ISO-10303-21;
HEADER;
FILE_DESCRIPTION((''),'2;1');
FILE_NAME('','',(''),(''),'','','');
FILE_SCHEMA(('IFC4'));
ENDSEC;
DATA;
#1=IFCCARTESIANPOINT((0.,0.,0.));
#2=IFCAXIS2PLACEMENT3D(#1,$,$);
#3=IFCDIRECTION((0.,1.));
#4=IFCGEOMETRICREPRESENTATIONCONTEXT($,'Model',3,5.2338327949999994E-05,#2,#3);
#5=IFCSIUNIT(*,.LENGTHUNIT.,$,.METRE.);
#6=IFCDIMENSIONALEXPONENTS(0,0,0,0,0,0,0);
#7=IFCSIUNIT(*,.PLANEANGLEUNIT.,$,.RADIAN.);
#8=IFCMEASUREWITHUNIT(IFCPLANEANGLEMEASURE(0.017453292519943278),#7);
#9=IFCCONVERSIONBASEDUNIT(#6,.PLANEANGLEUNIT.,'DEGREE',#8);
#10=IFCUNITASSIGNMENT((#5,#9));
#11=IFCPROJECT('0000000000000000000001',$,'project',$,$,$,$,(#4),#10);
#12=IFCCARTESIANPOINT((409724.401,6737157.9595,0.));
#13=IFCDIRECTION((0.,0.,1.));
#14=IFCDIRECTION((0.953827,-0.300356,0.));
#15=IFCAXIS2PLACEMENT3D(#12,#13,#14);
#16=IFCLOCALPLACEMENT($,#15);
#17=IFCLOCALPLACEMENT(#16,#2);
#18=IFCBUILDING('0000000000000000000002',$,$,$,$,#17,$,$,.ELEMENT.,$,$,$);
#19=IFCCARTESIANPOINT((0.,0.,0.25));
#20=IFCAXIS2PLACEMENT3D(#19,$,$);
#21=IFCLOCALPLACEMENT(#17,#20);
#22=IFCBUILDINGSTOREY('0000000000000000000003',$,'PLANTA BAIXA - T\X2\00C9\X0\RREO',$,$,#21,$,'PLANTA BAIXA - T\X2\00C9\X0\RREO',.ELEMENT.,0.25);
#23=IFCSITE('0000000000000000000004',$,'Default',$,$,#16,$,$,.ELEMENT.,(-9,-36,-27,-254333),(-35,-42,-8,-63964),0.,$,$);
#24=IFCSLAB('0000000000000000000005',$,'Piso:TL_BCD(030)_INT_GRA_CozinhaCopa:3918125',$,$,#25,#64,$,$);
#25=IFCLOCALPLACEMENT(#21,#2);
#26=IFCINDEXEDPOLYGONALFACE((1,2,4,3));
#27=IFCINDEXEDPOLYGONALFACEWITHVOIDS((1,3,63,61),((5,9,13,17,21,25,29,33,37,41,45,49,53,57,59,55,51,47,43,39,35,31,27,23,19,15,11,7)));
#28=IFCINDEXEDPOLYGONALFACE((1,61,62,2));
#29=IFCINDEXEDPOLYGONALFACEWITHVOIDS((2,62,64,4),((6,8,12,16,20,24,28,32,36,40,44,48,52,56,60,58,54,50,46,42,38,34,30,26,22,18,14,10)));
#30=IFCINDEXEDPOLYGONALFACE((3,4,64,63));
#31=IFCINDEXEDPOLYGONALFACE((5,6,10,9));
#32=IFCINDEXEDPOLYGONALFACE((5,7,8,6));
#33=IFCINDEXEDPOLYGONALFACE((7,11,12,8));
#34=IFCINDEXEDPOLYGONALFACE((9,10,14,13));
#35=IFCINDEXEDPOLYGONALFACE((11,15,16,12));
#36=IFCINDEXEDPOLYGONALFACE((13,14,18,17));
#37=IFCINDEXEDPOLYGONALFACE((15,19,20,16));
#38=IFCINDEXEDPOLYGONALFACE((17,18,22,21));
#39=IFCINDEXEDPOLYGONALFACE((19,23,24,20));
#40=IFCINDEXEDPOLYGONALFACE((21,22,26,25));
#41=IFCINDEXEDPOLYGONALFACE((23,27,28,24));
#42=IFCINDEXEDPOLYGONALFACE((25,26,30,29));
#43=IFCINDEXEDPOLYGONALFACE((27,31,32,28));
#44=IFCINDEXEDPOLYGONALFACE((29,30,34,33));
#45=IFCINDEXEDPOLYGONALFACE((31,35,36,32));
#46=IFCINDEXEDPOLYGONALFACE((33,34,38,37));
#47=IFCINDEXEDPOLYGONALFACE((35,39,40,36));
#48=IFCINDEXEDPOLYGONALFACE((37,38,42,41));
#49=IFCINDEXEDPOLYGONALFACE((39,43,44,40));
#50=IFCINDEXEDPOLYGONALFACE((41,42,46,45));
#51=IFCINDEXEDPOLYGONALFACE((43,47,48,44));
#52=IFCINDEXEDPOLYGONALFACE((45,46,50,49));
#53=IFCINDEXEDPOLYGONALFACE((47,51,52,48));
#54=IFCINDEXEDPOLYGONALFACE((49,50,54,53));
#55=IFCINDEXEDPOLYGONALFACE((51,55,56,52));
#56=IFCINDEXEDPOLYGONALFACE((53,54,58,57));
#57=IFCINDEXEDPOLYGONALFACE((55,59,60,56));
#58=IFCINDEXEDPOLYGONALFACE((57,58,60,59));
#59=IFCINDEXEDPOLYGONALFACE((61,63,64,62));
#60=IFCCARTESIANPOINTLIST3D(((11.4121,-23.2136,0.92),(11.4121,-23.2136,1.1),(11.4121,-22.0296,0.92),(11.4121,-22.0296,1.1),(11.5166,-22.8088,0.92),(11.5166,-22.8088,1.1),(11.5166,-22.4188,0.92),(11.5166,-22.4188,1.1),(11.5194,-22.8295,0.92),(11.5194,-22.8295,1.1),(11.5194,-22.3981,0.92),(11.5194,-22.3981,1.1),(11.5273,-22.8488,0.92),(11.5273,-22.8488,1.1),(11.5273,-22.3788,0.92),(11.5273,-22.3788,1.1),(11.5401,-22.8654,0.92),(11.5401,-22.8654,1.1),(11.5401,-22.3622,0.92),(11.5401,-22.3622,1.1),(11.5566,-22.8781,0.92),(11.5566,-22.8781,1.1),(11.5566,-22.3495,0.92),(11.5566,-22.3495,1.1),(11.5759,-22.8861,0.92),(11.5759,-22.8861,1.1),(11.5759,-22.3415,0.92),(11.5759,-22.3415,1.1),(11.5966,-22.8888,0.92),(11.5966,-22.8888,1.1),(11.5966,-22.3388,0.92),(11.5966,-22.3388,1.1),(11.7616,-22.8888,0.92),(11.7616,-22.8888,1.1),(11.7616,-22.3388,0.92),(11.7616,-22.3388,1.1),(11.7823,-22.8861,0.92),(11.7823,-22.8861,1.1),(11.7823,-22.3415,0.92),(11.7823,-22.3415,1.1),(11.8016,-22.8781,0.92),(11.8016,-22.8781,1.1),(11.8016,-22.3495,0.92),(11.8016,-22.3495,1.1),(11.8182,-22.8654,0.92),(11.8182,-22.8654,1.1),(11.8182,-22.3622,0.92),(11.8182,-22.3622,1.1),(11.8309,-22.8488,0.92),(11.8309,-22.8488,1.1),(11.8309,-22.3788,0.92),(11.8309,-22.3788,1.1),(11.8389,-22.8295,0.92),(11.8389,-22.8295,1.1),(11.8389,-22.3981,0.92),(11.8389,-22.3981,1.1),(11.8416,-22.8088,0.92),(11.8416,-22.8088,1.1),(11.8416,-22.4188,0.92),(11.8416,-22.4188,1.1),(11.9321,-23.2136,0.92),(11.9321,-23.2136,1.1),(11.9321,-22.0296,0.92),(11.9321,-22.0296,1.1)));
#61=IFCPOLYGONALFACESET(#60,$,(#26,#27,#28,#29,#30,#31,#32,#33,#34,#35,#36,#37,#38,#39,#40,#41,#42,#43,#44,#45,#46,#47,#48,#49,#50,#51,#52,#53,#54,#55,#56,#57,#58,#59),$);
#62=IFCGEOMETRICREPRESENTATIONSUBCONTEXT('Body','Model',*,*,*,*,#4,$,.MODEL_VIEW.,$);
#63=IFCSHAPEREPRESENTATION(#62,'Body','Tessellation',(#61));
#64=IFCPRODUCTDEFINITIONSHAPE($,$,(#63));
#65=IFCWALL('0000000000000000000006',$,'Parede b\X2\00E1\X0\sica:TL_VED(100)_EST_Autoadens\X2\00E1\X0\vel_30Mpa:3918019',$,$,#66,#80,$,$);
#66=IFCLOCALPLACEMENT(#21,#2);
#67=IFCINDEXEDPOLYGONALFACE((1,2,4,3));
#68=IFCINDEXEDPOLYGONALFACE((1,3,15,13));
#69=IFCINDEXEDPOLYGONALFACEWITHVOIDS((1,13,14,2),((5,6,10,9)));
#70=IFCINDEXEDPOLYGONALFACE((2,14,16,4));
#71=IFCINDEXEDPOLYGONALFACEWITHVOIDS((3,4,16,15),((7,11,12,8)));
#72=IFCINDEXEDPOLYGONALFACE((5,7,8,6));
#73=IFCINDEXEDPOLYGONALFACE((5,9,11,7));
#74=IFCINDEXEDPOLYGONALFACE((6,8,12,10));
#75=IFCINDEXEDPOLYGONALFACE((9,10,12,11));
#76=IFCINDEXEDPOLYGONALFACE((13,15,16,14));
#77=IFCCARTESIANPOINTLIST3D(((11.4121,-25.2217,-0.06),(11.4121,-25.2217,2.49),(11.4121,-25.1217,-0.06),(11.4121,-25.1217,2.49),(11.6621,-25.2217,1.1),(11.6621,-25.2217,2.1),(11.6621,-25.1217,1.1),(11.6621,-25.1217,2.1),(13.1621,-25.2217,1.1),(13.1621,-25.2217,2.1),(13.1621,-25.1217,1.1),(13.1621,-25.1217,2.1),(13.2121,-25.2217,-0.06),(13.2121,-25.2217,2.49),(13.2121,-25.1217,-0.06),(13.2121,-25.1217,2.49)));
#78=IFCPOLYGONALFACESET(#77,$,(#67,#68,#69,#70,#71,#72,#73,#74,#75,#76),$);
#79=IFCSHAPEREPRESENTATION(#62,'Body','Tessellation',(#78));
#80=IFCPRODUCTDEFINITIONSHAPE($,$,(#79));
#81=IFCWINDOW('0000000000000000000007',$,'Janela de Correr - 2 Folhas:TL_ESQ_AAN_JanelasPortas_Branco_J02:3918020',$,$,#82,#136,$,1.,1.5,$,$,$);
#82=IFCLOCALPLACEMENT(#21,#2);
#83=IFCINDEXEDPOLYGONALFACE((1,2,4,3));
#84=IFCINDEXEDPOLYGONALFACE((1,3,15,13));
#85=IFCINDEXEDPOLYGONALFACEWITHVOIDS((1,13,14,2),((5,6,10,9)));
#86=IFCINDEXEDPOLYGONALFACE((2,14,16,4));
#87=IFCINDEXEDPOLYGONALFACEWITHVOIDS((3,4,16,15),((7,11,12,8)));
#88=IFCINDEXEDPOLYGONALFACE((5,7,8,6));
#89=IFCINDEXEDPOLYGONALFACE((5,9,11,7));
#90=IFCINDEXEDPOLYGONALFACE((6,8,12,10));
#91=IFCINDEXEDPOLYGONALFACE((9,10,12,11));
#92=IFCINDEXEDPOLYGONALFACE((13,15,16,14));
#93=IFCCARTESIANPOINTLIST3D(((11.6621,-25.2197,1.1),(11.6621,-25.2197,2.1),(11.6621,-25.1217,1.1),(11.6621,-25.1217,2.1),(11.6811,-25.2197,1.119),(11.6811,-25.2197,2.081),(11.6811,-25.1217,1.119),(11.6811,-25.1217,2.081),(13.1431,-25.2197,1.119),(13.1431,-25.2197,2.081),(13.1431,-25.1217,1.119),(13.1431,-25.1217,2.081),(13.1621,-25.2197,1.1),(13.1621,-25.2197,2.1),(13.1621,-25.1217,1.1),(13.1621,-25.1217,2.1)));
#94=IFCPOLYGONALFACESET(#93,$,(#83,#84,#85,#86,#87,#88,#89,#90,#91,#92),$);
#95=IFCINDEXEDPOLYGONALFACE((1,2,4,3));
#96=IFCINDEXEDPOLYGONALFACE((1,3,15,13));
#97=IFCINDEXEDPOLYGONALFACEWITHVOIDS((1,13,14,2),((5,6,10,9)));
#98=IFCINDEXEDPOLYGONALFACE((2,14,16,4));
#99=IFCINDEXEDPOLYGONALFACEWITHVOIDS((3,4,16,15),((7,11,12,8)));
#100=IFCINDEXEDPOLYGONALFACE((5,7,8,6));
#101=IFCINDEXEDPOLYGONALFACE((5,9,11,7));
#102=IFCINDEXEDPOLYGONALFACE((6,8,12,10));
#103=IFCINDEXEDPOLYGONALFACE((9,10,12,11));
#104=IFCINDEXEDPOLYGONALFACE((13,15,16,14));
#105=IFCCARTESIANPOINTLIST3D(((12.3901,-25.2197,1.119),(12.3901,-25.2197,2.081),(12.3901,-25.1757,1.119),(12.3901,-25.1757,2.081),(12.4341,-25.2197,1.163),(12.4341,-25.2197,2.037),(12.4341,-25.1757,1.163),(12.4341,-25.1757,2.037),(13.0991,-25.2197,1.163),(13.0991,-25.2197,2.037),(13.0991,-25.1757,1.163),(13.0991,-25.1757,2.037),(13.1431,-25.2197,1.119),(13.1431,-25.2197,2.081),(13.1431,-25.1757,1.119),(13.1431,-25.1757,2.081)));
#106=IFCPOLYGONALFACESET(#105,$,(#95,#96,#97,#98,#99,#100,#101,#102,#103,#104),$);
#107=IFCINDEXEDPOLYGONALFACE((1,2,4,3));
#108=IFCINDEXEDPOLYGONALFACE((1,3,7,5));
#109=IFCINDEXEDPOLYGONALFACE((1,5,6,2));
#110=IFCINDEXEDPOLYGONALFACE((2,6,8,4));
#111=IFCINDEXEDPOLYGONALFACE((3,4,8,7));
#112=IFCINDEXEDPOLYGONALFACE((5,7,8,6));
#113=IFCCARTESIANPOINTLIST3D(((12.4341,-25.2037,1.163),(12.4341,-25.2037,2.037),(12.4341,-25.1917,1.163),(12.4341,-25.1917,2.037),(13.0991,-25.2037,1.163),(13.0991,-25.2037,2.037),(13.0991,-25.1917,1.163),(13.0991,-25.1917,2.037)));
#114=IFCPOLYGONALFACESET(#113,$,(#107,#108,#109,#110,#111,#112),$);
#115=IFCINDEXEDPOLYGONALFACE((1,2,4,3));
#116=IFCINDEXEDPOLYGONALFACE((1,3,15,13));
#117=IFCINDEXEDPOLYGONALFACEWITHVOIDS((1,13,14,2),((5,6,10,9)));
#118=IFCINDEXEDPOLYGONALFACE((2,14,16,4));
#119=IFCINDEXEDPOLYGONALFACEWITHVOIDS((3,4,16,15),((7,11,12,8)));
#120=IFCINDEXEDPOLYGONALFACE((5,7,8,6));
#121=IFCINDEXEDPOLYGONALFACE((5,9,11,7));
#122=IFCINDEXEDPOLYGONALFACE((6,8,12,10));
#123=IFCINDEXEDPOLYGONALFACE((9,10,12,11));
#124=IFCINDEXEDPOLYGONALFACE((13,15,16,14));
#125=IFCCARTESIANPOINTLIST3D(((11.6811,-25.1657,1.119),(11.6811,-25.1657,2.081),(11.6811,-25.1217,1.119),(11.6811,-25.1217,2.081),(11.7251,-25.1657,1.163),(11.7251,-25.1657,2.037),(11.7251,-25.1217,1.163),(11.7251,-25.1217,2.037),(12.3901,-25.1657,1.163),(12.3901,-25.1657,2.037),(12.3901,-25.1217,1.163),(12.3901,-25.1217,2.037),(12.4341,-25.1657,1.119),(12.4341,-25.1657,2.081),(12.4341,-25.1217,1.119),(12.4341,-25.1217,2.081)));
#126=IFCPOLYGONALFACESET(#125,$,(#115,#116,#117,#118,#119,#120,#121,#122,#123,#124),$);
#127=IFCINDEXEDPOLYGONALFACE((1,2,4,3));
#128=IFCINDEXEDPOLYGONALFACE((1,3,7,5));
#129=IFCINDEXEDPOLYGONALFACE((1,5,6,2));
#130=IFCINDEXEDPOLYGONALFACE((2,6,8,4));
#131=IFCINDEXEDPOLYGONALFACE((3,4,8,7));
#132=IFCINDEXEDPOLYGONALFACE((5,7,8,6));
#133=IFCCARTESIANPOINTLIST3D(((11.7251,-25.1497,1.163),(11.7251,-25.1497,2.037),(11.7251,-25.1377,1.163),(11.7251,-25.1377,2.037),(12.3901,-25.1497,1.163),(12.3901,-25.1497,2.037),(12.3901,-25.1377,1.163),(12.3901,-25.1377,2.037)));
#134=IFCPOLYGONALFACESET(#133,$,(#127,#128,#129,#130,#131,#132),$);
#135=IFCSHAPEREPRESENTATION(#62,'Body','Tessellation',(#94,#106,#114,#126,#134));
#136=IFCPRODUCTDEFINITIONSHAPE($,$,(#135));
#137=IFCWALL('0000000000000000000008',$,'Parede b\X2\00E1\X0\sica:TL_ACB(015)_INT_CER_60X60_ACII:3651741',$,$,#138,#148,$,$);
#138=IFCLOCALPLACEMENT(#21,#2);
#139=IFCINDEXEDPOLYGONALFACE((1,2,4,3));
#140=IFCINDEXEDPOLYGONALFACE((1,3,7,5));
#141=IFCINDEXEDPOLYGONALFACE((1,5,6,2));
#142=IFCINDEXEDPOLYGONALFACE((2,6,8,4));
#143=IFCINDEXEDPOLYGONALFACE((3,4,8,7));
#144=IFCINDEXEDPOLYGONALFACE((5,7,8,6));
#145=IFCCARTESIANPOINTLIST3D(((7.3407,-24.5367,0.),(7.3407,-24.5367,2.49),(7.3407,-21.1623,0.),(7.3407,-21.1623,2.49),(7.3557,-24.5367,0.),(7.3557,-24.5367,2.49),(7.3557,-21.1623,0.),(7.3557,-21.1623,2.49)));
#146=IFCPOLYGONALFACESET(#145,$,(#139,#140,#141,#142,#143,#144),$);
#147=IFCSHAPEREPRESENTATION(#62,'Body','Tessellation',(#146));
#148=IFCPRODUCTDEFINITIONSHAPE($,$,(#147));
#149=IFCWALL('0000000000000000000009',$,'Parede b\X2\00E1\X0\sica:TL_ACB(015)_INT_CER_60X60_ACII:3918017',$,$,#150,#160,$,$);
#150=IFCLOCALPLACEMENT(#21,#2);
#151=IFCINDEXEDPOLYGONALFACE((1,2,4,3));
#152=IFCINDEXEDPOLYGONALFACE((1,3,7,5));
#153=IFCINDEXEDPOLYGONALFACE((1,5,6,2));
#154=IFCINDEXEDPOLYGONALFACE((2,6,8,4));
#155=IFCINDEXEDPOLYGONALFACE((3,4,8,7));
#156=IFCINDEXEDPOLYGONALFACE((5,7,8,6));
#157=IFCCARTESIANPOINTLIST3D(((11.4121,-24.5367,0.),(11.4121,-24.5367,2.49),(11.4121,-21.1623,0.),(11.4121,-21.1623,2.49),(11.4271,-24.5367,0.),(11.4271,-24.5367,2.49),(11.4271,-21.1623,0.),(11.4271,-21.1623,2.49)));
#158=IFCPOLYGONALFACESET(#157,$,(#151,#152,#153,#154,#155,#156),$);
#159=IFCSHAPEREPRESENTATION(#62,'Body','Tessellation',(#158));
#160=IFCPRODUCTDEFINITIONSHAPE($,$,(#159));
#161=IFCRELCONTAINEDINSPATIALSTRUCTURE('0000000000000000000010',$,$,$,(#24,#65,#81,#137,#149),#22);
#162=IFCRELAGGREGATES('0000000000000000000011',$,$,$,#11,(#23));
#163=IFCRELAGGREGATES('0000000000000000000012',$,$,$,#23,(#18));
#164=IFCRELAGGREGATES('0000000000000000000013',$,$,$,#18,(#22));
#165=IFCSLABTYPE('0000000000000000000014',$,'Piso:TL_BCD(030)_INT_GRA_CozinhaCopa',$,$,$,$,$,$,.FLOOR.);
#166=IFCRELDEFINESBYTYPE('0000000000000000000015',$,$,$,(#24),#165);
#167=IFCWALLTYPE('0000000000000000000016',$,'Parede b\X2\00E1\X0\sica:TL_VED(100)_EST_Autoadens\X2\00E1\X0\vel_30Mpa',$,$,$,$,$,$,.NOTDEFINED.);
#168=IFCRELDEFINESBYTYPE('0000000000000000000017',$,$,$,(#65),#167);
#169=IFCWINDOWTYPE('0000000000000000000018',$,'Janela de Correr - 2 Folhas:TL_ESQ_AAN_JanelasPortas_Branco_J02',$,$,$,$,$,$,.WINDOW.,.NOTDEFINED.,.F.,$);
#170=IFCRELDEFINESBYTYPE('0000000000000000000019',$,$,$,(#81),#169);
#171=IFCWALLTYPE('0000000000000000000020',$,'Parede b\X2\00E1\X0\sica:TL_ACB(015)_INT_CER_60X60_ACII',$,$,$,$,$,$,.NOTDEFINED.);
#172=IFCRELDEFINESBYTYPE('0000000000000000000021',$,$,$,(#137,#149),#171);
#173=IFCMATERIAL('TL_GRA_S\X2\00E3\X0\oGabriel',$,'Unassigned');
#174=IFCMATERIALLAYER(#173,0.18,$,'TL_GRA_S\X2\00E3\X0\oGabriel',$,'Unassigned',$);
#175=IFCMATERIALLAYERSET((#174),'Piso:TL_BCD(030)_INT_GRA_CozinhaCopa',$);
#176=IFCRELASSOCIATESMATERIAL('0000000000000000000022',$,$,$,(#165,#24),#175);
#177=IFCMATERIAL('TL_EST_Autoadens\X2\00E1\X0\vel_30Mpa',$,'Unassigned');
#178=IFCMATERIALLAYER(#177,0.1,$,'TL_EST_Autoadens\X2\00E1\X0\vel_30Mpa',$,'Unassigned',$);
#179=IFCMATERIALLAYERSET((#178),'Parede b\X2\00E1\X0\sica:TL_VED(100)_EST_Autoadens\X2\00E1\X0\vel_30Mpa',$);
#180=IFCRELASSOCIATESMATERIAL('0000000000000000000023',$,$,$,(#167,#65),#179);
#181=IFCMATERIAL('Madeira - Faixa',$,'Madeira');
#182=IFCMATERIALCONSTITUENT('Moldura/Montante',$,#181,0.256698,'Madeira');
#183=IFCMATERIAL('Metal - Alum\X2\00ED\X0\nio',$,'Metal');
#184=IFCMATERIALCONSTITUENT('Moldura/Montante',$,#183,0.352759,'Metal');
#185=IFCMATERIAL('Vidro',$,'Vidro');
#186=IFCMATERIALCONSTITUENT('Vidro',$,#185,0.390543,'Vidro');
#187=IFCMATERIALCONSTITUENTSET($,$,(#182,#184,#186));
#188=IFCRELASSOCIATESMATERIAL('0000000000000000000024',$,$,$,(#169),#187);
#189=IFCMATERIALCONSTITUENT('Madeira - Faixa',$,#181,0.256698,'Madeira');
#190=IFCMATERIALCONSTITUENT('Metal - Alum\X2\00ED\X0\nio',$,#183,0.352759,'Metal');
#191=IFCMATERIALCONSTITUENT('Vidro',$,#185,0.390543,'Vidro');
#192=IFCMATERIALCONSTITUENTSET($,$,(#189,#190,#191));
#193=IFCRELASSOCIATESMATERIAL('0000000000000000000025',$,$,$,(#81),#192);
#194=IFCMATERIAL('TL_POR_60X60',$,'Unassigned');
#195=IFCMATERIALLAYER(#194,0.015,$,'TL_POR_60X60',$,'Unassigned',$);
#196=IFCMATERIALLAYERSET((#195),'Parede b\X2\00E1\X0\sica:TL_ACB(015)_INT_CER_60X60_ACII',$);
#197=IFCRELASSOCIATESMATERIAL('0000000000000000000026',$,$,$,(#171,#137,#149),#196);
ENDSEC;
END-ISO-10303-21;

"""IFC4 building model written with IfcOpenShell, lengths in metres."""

from ifc_helpers import new_model, entity, si_unit, converted_unit, direction, frame, frame_2d, origin, origin_2d_with_axis, place, context, subcontext, project, spatial, polyline, circle_curve, parameter, trimmed, segment, composite_curve, rectangle, outline, extrude, source, transform, mapped, material, layer, layer_set, layer_usage, constituent, constituent_set, type_object, type_shapes, element, fill, save


model = new_model("IFC4")

# Units and contexts
model_context = context("Model", 3, precision=5.2338327949999994e-05, world=origin(), true_north=direction((0.0, 1.0)))
body_context = subcontext(model_context, "Body", "Model", "MODEL_VIEW")
ifc_project = project(units=[si_unit("LENGTHUNIT", "METRE"), converted_unit("PLANEANGLEUNIT", "DEGREE", entity("IfcPlaneAngleMeasure", 0.017453292519943278), si_unit("PLANEANGLEUNIT", "RADIAN"), dimensions=[0, 0, 0, 0, 0, 0, 0])], contexts=[model_context])

# Site, building, storey
site_placement = place(None, frame((409724.401, 6737157.9595, 0.0), z_axis=(0.0, 0.0, 1.0), x_axis=(0.953827, -0.300356, 0.0)))
site = spatial("IfcSite", under=ifc_project, at=site_placement, Name="Default", CompositionType="ELEMENT", RefLatitude=(-9, -36, -27, -254333), RefLongitude=(-35, -42, -8, -63964), RefElevation=0.0)
building_placement = place(site_placement, origin())
building = spatial("IfcBuilding", under=site, at=building_placement, CompositionType="ELEMENT")
storey_placement = place(building_placement, frame((0.0, 0.0, 0.25)))
storey = spatial("IfcBuildingStorey", under=building, at=storey_placement, Name="PLANTA BAIXA - TÉRREO", LongName="PLANTA BAIXA - TÉRREO", CompositionType="ELEMENT", Elevation=0.25)

# Shared definitions
ifc_material_1 = material(Name="TL_POR_60X60", Category="Unassigned")

# Slab, opening
ifc_material_2 = material(Name="TL_GRA_SãoGabriel", Category="Unassigned")
ifc_layer_1 = layer(ifc_material_2, 0.18, Name="TL_GRA_SãoGabriel", Category="Unassigned")
ifc_layer_set_1 = layer_set([ifc_layer_1], Name="Piso:TL_BCD(030)_INT_GRA_CozinhaCopa")
ifc_layer_usage_1 = layer_usage(ifc_layer_set_1, "AXIS3", "POSITIVE", 0.0)
slab_type_1 = type_object("IfcSlabType", Name="Piso:TL_BCD(030)_INT_GRA_CozinhaCopa", PredefinedType="FLOOR", material=ifc_layer_set_1)
slab_1_placement = place(storey_placement, frame((11.4121, -23.2136, 0.92)))
slab_1 = element("IfcSlab", 1, at=slab_1_placement, inside=storey, type_object=slab_type_1, material=ifc_layer_usage_1, Name="Piso:TL_BCD(030)_INT_GRA_CozinhaCopa:3918125", context=body_context, shape_type="SweptSolid", body=[
    extrude(rectangle(XDim=1.184, YDim=0.52, at=frame_2d((0.0, 0.0), x_axis=(0.0, 1.0))), frame((0.26, 0.592, 0.18), z_axis=(0.0, 0.0, -1.0), x_axis=(-1.0, 0.0, 0.0)), (0.0, 0.0, 1.0), 0.18),
])
opening_1_placement = place(slab_1_placement, frame((-11.4121, 23.2136, 0.18)))
element("IfcOpeningElement", 2, at=opening_1_placement, cuts=slab_1, PredefinedType="OPENING", context=body_context, shape_type="SweptSolid", body=[
    extrude(outline(composite_curve([segment(polyline([(-0.195, -0.1625), (0.195, -0.1625)]), True, "CONTINUOUS"), segment(trimmed(circle_curve(frame_2d((0.195, -0.0825), x_axis=(-1.0, 0.0)), 0.08), [parameter(90.0)], [parameter(180.0)], True, "PARAMETER"), True, "CONTINUOUS"), segment(polyline([(0.275, -0.0825), (0.275, 0.0825)]), True, "CONTINUOUS"), segment(trimmed(circle_curve(frame_2d((0.195, 0.0825), x_axis=(-1.0, 0.0)), 0.08), [parameter(180.0)], [parameter(270.0)], True, "PARAMETER"), True, "CONTINUOUS"), segment(polyline([(0.195, 0.1625), (-0.195, 0.1625)]), True, "CONTINUOUS"), segment(trimmed(circle_curve(frame_2d((-0.195, 0.0825), x_axis=(-1.0, 0.0)), 0.08), [parameter(270.0)], [parameter(360.0)], True, "PARAMETER"), True, "CONTINUOUS"), segment(polyline([(-0.275, 0.0825), (-0.275, -0.0825)]), True, "CONTINUOUS"), segment(trimmed(circle_curve(frame_2d((-0.195, -0.0825), x_axis=(-1.0, 0.0)), 0.08), [parameter(360.0)], [parameter(90.0)], True, "PARAMETER"), True, "CONTINUOUS")], self_intersect=False)), frame((11.6791, -22.6138, -0.21), z_axis=(0.0, 0.0, 1.0), x_axis=(0.0, -1.0, 0.0)), (0.0, 0.0, 1.0), 0.21),
])

# Wall, opening, window
ifc_material_3 = material(Name="TL_EST_Autoadensável_30Mpa", Category="Unassigned")
ifc_layer_2 = layer(ifc_material_3, 0.1, Name="TL_EST_Autoadensável_30Mpa", Category="Unassigned")
ifc_layer_set_2 = layer_set([ifc_layer_2], Name="Parede básica:TL_VED(100)_EST_Autoadensável_30Mpa")
ifc_layer_usage_2 = layer_usage(ifc_layer_set_2, "AXIS2", "NEGATIVE", 0.05)
wall_type_1 = type_object("IfcWallType", Name="Parede básica:TL_VED(100)_EST_Autoadensável_30Mpa", PredefinedType="NOTDEFINED", material=ifc_layer_set_2)
wall_1_placement = place(storey_placement, frame((13.2121, -25.1717, -0.06), z_axis=(0.0, 0.0, 1.0), x_axis=(-1.0, 0.0, 0.0)))
wall_1 = element("IfcWall", 3, at=wall_1_placement, inside=storey, type_object=wall_type_1, material=ifc_layer_usage_2, Name="Parede básica:TL_VED(100)_EST_Autoadensável_30Mpa:3918019", context=body_context, shape_type="SweptSolid", body=[
    extrude(rectangle(XDim=1.8, YDim=0.1, at=frame_2d((0.9, 0.0), x_axis=(-1.0, 0.0))), origin(), (0.0, 0.0, 1.0), 2.55),
])
opening_2_placement = place(wall_1_placement, frame((0.05, -0.05, 1.16)))
opening_2 = element("IfcOpeningElement", 4, at=opening_2_placement, cuts=wall_1, PredefinedType="OPENING", context=body_context, shape_type="SweptSolid", body=[
    extrude(rectangle(XDim=1.0, YDim=1.5, at=frame_2d((0.5, 0.75), x_axis=(-1.0, 0.0))), frame((0.0, 0.0, 0.0), z_axis=(0.0, 1.0, 0.0), x_axis=(0.0, 0.0, 1.0)), (0.0, 0.0, 1.0), 0.1),
])
ifc_material_4 = material(Name="Madeira - Faixa", Category="Madeira")
ifc_constituent_1 = constituent(ifc_material_4, Name="Madeira - Faixa", Category="Madeira", fraction=0.256698)
ifc_material_5 = material(Name="Metal - Alumínio", Category="Metal")
ifc_constituent_2 = constituent(ifc_material_5, Name="Metal - Alumínio", Category="Metal", fraction=0.352759)
ifc_material_6 = material(Name="Vidro", Category="Vidro")
ifc_constituent_3 = constituent(ifc_material_6, Name="Vidro", Category="Vidro", fraction=0.390543)
ifc_constituent_set_1 = constituent_set(constituents=[ifc_constituent_1, ifc_constituent_2, ifc_constituent_3])
ifc_constituent_4 = constituent(ifc_material_4, Name="Moldura/Montante", Category="Madeira", fraction=0.256698)
ifc_constituent_5 = constituent(ifc_material_5, Name="Moldura/Montante", Category="Metal", fraction=0.352759)
ifc_constituent_6 = constituent(ifc_material_6, Name="Vidro", Category="Vidro", fraction=0.390543)
ifc_constituent_set_2 = constituent_set(constituents=[ifc_constituent_4, ifc_constituent_5, ifc_constituent_6])
window_type = type_object("IfcWindowType", Name="Janela de Correr - 2 Folhas:TL_ESQ_AAN_JanelasPortas_Branco_J02", ParameterTakesPrecedence=False, PartitioningType="NOTDEFINED", PredefinedType="WINDOW", material=ifc_constituent_set_2)
shared_shape_1 = source(origin(), body_context, "Body", "SweptSolid", [
    extrude(outline(polyline([(-0.75, -0.5), (0.75, -0.5), (0.75, 0.5), (-0.75, 0.5), (-0.75, -0.5)]), holes=[polyline([(-0.731, -0.481), (-0.731, 0.481), (0.731, 0.481), (0.731, -0.481), (-0.731, -0.481)])]), frame((0.75, 0.124, 0.5), z_axis=(0.0, -1.0, 0.0), x_axis=(-1.0, 0.0, 0.0)), (0.0, 0.0, 1.0), 0.098),
    extrude(outline(polyline([(-0.3765, -0.481), (0.3765, -0.481), (0.3765, 0.481), (-0.3765, 0.481), (-0.3765, -0.481)]), holes=[polyline([(-0.3325, -0.437), (-0.3325, 0.437), (0.3325, 0.437), (0.3325, -0.437), (-0.3325, -0.437)])]), frame((0.3955, 0.124, 0.5), z_axis=(0.0, -1.0, 0.0), x_axis=(-1.0, 0.0, 0.0)), (0.0, 0.0, 1.0), 0.044),
    extrude(rectangle(XDim=0.665, YDim=0.012, at=origin_2d_with_axis()), frame((0.3955, 0.102, 0.063), z_axis=(0.0, 0.0, 1.0), x_axis=(-1.0, 0.0, 0.0)), (0.0, 0.0, 1.0), 0.874),
    extrude(outline(polyline([(-0.481, -0.3765), (0.481, -0.3765), (0.481, 0.3765), (-0.481, 0.3765), (-0.481, -0.3765)]), holes=[polyline([(-0.437, -0.3325), (-0.437, 0.3325), (0.437, 0.3325), (0.437, -0.3325), (-0.437, -0.3325)])]), frame((1.1045, 0.07, 0.5), z_axis=(0.0, -1.0, 0.0), x_axis=(0.0, 0.0, -1.0)), (0.0, 0.0, 1.0), 0.044),
    extrude(rectangle(XDim=0.665, YDim=0.012, at=origin_2d_with_axis()), frame((1.1045, 0.048, 0.063), z_axis=(0.0, 0.0, 1.0), x_axis=(-1.0, 0.0, 0.0)), (0.0, 0.0, 1.0), 0.874),
])
type_shapes(window_type, [shared_shape_1])
window_placement = place(opening_2_placement, frame((0.0, -0.026, 0.0)))
window = element("IfcWindow", 5, at=window_placement, inside=storey, type_object=window_type, material=ifc_constituent_set_1, Name="Janela de Correr - 2 Folhas:TL_ESQ_AAN_JanelasPortas_Branco_J02:3918020", OverallHeight=1.0, OverallWidth=1.5, context=body_context, shape_type="MappedRepresentation", body=[
    mapped(shared_shape_1, transform((0.0, 0.0, 0.0), scale=1.0)),
])
fill(opening_2, window)

# Walls
ifc_layer_3 = layer(ifc_material_1, 0.015, Name="TL_POR_60X60", Category="Unassigned")
ifc_layer_set_3 = layer_set([ifc_layer_3], Name="Parede básica:TL_ACB(015)_INT_CER_60X60_ACII")
ifc_layer_usage_3 = layer_usage(ifc_layer_set_3, "AXIS2", "POSITIVE", -0.0075)
wall_type_2 = type_object("IfcWallType", Name="Parede básica:TL_ACB(015)_INT_CER_60X60_ACII", PredefinedType="NOTDEFINED", material=ifc_layer_set_3)
wall_2_placement = place(storey_placement, frame((7.3482, -21.1623, 0.0), z_axis=(0.0, 0.0, 1.0), x_axis=(0.0, -1.0, 0.0)))
element("IfcWall", 6, at=wall_2_placement, inside=storey, type_object=wall_type_2, material=ifc_layer_usage_3, Name="Parede básica:TL_ACB(015)_INT_CER_60X60_ACII:3651741", context=body_context, shape_type="SweptSolid", body=[
    extrude(rectangle(XDim=3.3744, YDim=0.015, at=frame_2d((1.6872, 0.0), x_axis=(-1.0, 0.0))), origin(), (0.0, 0.0, 1.0), 2.49),
])
ifc_layer_usage_4 = layer_usage(ifc_layer_set_3, "AXIS2", "NEGATIVE", 0.0075)
wall_3_placement = place(storey_placement, frame((11.4196, -21.1623, 0.0), z_axis=(0.0, 0.0, 1.0), x_axis=(0.0, -1.0, 0.0)))
element("IfcWall", 7, at=wall_3_placement, inside=storey, type_object=wall_type_2, material=ifc_layer_usage_4, Name="Parede básica:TL_ACB(015)_INT_CER_60X60_ACII:3918017", context=body_context, shape_type="SweptSolid", body=[
    extrude(rectangle(XDim=3.3744, YDim=0.015, at=frame_2d((1.6872, 0.0), x_axis=(-1.0, 0.0))), origin(), (0.0, 0.0, 1.0), 2.49),
])

save(model, "model.ifc")
